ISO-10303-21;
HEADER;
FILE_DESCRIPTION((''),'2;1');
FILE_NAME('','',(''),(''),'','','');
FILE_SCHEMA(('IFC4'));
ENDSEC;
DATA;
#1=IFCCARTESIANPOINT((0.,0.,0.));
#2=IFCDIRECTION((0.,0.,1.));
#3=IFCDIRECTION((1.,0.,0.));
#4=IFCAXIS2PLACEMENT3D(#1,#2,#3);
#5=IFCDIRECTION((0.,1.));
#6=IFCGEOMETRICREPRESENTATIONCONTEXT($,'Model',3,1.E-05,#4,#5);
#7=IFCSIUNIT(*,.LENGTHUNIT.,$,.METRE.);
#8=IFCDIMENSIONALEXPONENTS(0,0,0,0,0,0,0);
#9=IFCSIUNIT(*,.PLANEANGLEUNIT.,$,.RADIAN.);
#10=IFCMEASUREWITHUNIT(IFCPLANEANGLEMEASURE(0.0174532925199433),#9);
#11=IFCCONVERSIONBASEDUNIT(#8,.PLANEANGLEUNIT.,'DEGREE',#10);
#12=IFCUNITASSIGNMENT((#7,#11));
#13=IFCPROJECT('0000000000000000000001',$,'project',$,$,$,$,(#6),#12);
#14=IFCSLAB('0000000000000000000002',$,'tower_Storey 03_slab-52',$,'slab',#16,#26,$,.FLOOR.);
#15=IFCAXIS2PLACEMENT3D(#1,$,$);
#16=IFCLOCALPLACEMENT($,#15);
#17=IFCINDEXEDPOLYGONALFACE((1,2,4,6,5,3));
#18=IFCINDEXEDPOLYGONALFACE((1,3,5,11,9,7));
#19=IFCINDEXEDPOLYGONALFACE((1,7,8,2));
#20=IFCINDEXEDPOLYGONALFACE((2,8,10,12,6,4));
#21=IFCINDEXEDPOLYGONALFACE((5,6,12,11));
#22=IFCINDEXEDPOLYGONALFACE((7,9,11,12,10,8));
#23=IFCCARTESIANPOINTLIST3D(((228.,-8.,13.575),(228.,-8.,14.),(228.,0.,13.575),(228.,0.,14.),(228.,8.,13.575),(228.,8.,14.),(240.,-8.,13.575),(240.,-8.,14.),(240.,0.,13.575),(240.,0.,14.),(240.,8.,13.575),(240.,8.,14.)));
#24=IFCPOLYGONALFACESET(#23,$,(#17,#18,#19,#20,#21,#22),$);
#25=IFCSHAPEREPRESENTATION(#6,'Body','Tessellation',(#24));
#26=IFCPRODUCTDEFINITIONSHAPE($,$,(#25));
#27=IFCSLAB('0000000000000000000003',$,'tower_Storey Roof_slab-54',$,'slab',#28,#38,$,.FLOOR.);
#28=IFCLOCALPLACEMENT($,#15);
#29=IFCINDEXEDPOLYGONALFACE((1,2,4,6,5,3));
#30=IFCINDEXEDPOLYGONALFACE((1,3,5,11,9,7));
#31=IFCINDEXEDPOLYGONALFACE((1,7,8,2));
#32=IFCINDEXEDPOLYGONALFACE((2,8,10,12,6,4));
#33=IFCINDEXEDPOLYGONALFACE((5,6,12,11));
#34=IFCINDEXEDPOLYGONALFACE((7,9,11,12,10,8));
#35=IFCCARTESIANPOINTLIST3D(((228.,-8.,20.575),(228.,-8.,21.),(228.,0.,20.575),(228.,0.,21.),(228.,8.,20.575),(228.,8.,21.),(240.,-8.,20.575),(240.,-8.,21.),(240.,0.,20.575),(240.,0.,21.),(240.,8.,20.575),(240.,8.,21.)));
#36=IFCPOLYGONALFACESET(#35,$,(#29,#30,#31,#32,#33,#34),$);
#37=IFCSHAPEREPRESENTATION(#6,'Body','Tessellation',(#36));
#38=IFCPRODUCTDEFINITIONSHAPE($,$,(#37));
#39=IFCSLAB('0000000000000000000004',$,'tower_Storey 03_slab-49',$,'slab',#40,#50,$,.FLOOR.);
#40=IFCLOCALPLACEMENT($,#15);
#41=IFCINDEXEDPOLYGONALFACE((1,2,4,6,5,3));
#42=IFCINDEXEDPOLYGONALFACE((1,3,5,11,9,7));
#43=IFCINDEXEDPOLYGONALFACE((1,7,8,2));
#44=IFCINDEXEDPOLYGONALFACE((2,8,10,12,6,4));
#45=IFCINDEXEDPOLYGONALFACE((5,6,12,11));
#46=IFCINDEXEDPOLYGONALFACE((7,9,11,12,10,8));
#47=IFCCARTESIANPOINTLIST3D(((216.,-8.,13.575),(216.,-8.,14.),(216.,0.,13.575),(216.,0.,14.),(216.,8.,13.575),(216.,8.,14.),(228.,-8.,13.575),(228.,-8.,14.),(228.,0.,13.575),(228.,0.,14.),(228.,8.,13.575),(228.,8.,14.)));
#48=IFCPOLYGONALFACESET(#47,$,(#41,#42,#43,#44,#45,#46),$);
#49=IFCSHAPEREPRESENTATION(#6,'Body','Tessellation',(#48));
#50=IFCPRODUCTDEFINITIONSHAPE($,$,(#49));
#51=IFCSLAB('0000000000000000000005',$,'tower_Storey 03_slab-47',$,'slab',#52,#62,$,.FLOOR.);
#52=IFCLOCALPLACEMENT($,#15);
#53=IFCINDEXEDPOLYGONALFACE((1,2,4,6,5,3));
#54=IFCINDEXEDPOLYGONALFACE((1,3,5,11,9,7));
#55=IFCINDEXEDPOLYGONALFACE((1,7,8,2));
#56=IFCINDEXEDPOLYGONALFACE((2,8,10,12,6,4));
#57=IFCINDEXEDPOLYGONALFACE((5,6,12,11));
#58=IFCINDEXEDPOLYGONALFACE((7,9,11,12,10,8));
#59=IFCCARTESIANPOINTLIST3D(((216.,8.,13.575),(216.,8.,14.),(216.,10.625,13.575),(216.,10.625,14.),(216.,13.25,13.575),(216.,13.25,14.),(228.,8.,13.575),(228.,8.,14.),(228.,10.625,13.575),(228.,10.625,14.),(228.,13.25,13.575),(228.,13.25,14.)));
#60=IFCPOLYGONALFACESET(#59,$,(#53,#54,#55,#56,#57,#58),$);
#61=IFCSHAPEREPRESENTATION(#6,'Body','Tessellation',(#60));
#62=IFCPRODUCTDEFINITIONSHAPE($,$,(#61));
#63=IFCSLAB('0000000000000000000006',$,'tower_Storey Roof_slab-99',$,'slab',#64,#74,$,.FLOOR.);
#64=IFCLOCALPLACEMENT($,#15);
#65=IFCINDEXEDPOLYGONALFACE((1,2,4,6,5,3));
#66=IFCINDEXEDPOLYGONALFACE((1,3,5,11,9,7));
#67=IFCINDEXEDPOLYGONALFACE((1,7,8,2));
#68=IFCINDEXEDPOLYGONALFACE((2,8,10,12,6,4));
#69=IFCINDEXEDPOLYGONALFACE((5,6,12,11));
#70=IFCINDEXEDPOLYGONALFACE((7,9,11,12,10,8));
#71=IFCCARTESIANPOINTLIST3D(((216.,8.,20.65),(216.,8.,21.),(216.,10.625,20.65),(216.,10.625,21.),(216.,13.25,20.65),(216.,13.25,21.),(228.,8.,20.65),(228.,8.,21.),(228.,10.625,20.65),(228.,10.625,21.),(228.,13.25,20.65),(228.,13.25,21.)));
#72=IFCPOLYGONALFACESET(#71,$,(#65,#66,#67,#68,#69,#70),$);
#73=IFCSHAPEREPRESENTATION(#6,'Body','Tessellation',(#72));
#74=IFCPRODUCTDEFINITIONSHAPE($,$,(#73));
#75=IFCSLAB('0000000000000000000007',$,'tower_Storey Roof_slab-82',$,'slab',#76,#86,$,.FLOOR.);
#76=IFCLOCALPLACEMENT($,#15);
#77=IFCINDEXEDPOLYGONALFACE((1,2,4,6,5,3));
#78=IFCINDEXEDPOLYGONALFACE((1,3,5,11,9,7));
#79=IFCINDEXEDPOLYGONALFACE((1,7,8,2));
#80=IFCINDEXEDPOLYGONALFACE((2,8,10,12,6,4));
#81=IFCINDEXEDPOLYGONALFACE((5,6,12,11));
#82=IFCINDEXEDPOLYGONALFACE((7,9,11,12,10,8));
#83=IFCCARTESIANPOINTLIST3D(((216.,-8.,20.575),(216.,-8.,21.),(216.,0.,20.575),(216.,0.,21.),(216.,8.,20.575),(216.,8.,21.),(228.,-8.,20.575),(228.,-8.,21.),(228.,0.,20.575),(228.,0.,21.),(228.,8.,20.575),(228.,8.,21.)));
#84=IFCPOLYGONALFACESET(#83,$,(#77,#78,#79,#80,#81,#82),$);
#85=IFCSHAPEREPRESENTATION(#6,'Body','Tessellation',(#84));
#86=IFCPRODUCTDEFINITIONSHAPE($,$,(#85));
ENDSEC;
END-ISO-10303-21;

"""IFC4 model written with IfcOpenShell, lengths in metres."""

from ifc_helpers import new_model, entity, si_unit, converted_unit, direction, frame, origin_with_axes, place, context, project, polyline, outline, extrude, element, save


model = new_model("IFC4")

# Units and contexts
model_context = context("Model", 3, precision=1e-05, world=origin_with_axes(), true_north=direction((0.0, 1.0)))
ifc_project = project(units=[si_unit("LENGTHUNIT", "METRE"), converted_unit("PLANEANGLEUNIT", "DEGREE", entity("IfcPlaneAngleMeasure", 0.0174532925199433), si_unit("PLANEANGLEUNIT", "RADIAN"), dimensions=[0, 0, 0, 0, 0, 0, 0])], contexts=[model_context])

# Shared definitions
placement_1 = place(None, origin_with_axes())
placement_2 = place(placement_1, frame((0.0, 0.0, 14.0), z_axis=(0.0, 0.0, 1.0), x_axis=(1.0, 0.0, 0.0)))

# Shared definitions
placement_3 = place(placement_1, frame((0.0, 0.0, 21.0), z_axis=(0.0, 0.0, 1.0), x_axis=(1.0, 0.0, 0.0)))

# Slabs
slab_1_placement = place(placement_2, frame((234.0, 0.0, -0.425), z_axis=(0.0, 0.0, 1.0), x_axis=(1.0, 0.0, 0.0)))
element("IfcSlab", 1, at=slab_1_placement, Name="tower_Storey 03_slab-52", ObjectType="slab", PredefinedType="FLOOR", context=model_context, body=[
    extrude(outline(polyline([(-6.0, -8.0, 0.0), (6.0, -8.0, 0.0), (6.0, 0.0, 0.0), (6.0, 8.0, 0.0), (-6.0, 8.0, 0.0), (-6.0, 0.0, 0.0), (-6.0, -8.0, 0.0)])), origin_with_axes(), (0.0, 0.0, 1.0), 0.425),
])
slab_2_placement = place(placement_3, frame((234.0, 0.0, -0.425), z_axis=(0.0, 0.0, 1.0), x_axis=(1.0, 0.0, 0.0)))
element("IfcSlab", 2, at=slab_2_placement, Name="tower_Storey Roof_slab-54", ObjectType="slab", PredefinedType="FLOOR", context=model_context, body=[
    extrude(outline(polyline([(-6.0, -8.0, 0.0), (6.0, -8.0, 0.0), (6.0, 0.0, 0.0), (6.0, 8.0, 0.0), (-6.0, 8.0, 0.0), (-6.0, 0.0, 0.0), (-6.0, -8.0, 0.0)])), origin_with_axes(), (0.0, 0.0, 1.0), 0.425),
])
slab_3_placement = place(placement_2, frame((222.0, 0.0, -0.425), z_axis=(0.0, 0.0, 1.0), x_axis=(1.0, 0.0, 0.0)))
element("IfcSlab", 3, at=slab_3_placement, Name="tower_Storey 03_slab-49", ObjectType="slab", PredefinedType="FLOOR", context=model_context, body=[
    extrude(outline(polyline([(-6.0, -8.0, 0.0), (6.0, -8.0, 0.0), (6.0, 0.0, 0.0), (6.0, 8.0, 0.0), (-6.0, 8.0, 0.0), (-6.0, 0.0, 0.0), (-6.0, -8.0, 0.0)])), origin_with_axes(), (0.0, 0.0, 1.0), 0.425),
])
slab_4_placement = place(placement_2, frame((222.0, 10.625, -0.425), z_axis=(0.0, 0.0, 1.0), x_axis=(1.0, 0.0, 0.0)))
element("IfcSlab", 4, at=slab_4_placement, Name="tower_Storey 03_slab-47", ObjectType="slab", PredefinedType="FLOOR", context=model_context, body=[
    extrude(outline(polyline([(-6.0, -2.625, 0.0), (6.0, -2.625, 0.0), (6.0, 0.0, 0.0), (6.0, 2.625, 0.0), (-6.0, 2.625, 0.0), (-6.0, 0.0, 0.0), (-6.0, -2.625, 0.0)])), origin_with_axes(), (0.0, 0.0, 1.0), 0.425),
])
slab_5_placement = place(placement_3, frame((222.0, 10.625, -0.35), z_axis=(0.0, 0.0, 1.0), x_axis=(1.0, 0.0, 0.0)))
element("IfcSlab", 5, at=slab_5_placement, Name="tower_Storey Roof_slab-99", ObjectType="slab", PredefinedType="FLOOR", context=model_context, body=[
    extrude(outline(polyline([(-6.0, -2.625, 0.0), (6.0, -2.625, 0.0), (6.0, 0.0, 0.0), (6.0, 2.625, 0.0), (-6.0, 2.625, 0.0), (-6.0, 0.0, 0.0), (-6.0, -2.625, 0.0)])), origin_with_axes(), (0.0, 0.0, 1.0), 0.35),
])
slab_6_placement = place(placement_3, frame((222.0, 0.0, -0.425), z_axis=(0.0, 0.0, 1.0), x_axis=(1.0, 0.0, 0.0)))
element("IfcSlab", 6, at=slab_6_placement, Name="tower_Storey Roof_slab-82", ObjectType="slab", PredefinedType="FLOOR", context=model_context, body=[
    extrude(outline(polyline([(-6.0, -8.0, 0.0), (6.0, -8.0, 0.0), (6.0, 0.0, 0.0), (6.0, 8.0, 0.0), (-6.0, 8.0, 0.0), (-6.0, 0.0, 0.0), (-6.0, -8.0, 0.0)])), origin_with_axes(), (0.0, 0.0, 1.0), 0.425),
])

save(model, "model.ifc")
